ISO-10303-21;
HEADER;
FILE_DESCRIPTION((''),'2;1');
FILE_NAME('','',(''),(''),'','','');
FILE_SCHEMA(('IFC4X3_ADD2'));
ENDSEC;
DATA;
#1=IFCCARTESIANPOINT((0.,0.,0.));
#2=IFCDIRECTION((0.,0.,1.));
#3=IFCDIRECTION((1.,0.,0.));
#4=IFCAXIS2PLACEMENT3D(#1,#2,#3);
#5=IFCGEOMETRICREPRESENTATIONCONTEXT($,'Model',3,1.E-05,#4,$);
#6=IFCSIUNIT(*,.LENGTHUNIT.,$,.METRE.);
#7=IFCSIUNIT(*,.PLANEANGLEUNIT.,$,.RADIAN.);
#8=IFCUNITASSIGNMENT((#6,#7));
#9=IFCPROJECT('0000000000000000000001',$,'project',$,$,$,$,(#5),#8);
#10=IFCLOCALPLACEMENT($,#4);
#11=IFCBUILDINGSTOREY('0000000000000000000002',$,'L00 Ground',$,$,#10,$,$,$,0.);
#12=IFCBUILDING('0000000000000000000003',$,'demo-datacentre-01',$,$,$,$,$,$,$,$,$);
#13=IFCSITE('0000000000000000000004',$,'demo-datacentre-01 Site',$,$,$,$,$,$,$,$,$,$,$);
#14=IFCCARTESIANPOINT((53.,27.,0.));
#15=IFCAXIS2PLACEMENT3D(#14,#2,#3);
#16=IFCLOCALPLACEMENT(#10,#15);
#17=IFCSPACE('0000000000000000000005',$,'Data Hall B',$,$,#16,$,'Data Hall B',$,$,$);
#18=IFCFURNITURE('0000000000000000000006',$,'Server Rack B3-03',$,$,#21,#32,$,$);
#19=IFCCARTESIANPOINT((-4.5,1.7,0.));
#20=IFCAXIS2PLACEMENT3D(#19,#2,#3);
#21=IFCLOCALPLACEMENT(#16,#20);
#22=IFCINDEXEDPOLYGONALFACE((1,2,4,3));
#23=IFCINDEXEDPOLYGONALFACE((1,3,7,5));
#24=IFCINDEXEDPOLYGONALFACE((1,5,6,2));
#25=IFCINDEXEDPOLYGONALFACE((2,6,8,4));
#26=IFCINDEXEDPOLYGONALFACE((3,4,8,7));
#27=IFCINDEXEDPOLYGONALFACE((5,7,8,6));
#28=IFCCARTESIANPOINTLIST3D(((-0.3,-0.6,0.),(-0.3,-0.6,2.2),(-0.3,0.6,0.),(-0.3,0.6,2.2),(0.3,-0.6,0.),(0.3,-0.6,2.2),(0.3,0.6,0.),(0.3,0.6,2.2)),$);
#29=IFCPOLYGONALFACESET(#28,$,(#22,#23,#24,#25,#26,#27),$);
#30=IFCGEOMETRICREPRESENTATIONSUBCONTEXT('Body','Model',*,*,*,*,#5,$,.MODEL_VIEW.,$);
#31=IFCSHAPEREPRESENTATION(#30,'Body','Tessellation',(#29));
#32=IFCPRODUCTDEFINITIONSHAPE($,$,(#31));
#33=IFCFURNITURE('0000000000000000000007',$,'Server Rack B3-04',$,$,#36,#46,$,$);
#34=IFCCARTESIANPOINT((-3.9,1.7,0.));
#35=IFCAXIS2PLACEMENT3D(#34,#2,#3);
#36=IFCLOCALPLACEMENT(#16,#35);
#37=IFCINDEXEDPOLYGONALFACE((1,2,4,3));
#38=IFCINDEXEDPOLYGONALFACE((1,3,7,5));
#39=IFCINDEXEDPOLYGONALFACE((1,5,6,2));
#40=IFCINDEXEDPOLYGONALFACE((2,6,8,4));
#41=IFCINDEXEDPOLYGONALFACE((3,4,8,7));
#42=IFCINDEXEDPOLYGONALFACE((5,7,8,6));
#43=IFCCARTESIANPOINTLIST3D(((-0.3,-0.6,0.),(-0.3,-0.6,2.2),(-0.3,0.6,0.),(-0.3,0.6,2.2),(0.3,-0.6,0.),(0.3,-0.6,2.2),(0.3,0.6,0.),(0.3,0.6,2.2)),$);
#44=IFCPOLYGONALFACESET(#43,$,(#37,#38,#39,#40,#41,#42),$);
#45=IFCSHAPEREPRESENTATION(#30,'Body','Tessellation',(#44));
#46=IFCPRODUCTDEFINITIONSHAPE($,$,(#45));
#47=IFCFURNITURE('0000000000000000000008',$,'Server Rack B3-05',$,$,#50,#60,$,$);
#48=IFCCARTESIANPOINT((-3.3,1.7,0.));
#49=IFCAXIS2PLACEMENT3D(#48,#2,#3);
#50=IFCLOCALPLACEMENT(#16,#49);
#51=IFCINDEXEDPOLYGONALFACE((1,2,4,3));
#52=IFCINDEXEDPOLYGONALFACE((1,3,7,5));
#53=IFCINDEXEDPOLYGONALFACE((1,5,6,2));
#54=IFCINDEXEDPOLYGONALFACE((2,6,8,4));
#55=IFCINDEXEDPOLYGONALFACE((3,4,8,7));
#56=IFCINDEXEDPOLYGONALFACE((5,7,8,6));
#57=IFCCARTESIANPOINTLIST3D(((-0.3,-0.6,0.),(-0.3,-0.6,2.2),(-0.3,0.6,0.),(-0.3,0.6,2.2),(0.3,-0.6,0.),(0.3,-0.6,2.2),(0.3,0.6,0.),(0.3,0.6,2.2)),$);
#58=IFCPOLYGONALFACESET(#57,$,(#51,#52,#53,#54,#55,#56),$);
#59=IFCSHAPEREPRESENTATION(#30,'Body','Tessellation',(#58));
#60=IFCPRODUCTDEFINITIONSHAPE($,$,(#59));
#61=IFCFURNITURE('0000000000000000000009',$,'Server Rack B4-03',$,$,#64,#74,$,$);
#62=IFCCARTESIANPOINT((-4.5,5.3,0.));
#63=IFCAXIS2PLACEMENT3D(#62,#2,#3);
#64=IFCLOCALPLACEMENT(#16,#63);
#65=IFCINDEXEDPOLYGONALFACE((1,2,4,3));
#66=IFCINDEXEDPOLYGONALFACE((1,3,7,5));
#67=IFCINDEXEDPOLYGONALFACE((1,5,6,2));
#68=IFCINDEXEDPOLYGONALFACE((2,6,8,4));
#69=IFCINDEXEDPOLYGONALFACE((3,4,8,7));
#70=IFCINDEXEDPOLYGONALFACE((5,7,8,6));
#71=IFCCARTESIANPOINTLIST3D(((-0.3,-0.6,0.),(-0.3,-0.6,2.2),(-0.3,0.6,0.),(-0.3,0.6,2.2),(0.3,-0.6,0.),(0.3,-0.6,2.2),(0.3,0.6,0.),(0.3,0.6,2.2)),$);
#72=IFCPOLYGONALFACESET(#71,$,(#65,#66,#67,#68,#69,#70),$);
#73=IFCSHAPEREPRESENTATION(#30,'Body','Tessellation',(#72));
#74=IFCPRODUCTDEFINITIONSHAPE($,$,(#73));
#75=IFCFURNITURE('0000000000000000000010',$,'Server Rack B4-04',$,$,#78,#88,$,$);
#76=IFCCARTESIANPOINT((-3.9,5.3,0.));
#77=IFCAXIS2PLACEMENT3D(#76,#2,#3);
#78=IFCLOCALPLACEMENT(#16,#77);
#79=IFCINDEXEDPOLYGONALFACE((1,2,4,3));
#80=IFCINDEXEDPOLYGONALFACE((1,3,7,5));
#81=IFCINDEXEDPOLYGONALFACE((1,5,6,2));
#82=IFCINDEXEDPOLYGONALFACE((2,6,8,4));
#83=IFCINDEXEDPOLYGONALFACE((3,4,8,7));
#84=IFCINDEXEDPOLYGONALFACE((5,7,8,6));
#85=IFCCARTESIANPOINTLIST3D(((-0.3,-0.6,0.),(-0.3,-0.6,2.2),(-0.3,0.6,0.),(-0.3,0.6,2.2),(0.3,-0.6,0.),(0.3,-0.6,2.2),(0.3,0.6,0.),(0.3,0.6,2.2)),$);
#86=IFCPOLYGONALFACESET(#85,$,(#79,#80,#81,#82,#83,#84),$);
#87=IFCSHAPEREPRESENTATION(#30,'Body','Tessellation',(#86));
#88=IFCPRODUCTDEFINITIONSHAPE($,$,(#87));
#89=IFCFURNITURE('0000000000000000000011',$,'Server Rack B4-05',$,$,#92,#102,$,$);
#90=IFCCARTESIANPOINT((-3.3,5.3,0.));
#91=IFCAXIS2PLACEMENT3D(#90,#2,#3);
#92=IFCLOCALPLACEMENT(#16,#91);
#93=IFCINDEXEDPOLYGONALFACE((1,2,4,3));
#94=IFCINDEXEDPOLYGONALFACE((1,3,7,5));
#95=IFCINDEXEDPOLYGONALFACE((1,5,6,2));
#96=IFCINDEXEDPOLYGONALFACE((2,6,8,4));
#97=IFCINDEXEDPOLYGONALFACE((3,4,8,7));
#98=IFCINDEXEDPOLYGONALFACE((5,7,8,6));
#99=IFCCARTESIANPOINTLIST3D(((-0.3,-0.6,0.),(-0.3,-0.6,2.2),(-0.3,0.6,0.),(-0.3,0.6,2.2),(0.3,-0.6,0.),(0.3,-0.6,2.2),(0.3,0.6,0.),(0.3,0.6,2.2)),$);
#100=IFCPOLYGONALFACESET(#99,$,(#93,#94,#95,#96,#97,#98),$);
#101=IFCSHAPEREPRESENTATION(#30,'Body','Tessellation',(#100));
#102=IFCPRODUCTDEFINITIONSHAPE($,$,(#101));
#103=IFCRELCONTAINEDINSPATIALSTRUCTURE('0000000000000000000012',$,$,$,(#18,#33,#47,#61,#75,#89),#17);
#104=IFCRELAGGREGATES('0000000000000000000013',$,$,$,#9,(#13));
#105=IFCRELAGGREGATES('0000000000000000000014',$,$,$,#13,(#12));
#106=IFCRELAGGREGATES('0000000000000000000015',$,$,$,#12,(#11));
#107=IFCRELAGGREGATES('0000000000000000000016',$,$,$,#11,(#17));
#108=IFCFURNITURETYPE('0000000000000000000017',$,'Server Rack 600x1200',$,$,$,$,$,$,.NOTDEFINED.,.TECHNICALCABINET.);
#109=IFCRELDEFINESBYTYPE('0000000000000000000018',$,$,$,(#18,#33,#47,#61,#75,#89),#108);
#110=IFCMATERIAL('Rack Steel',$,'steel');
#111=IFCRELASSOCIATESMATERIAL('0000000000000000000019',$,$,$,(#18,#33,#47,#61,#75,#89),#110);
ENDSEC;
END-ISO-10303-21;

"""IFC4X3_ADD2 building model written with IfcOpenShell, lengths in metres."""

from ifc_helpers import new_model, si_unit, frame, origin_with_axes, place, context, subcontext, project, spatial, rectangle, extrude, material, type_object, element, save


model = new_model("IFC4X3_ADD2")

# Units and contexts
model_context = context("Model", 3, precision=1e-05, world=origin_with_axes())
body_context = subcontext(model_context, "Body", "Model", "MODEL_VIEW")
ifc_project = project(units=[si_unit("LENGTHUNIT", "METRE"), si_unit("PLANEANGLEUNIT", "RADIAN")], contexts=[model_context])

# Site, building, storey
site = spatial("IfcSite", under=ifc_project, Name="demo-datacentre-01 Site")
building = spatial("IfcBuilding", under=site, Name="demo-datacentre-01")
storey_placement = place(None, origin_with_axes())
storey = spatial("IfcBuildingStorey", under=building, at=storey_placement, Name="L00 Ground", Elevation=0.0)

# Shared definitions
space_placement = place(storey_placement, frame((53.0, 27.0, 0.0), z_axis=(0.0, 0.0, 1.0), x_axis=(1.0, 0.0, 0.0)))
space = spatial("IfcSpace", under=storey, at=space_placement, Name="Data Hall B", LongName="Data Hall B")

# Furniture
ifc_material_1 = material(Name="Rack Steel", Category="steel")
furniture_type = type_object("IfcFurnitureType", Name="Server Rack 600x1200", AssemblyPlace="NOTDEFINED", PredefinedType="TECHNICALCABINET")
for number, where, z_axis, x_axis, name in (
    (1, (-4.5, 1.7, 0.0), (0.0, 0.0, 1.0), (1.0, 0.0, 0.0), "Server Rack B3-03"),
    (2, (-3.9, 1.7, 0.0), (0.0, 0.0, 1.0), (1.0, 0.0, 0.0), "Server Rack B3-04"),
    (3, (-3.3, 1.7, 0.0), (0.0, 0.0, 1.0), (1.0, 0.0, 0.0), "Server Rack B3-05"),
    (4, (-4.5, 5.3, 0.0), (0.0, 0.0, 1.0), (1.0, 0.0, 0.0), "Server Rack B4-03"),
    (5, (-3.9, 5.3, 0.0), (0.0, 0.0, 1.0), (1.0, 0.0, 0.0), "Server Rack B4-04"),
    (6, (-3.3, 5.3, 0.0), (0.0, 0.0, 1.0), (1.0, 0.0, 0.0), "Server Rack B4-05"),
):
    element("IfcFurniture", number, at=place(space_placement, frame(where, z_axis=z_axis, x_axis=x_axis)), inside=space, type_object=furniture_type, material=ifc_material_1, Name=name, context=body_context, shape_type="SweptSolid", body=[
        extrude(rectangle(XDim=0.6, YDim=1.2), origin_with_axes(), (0.0, 0.0, 1.0), 2.2),
    ])

save(model, "model.ifc")
